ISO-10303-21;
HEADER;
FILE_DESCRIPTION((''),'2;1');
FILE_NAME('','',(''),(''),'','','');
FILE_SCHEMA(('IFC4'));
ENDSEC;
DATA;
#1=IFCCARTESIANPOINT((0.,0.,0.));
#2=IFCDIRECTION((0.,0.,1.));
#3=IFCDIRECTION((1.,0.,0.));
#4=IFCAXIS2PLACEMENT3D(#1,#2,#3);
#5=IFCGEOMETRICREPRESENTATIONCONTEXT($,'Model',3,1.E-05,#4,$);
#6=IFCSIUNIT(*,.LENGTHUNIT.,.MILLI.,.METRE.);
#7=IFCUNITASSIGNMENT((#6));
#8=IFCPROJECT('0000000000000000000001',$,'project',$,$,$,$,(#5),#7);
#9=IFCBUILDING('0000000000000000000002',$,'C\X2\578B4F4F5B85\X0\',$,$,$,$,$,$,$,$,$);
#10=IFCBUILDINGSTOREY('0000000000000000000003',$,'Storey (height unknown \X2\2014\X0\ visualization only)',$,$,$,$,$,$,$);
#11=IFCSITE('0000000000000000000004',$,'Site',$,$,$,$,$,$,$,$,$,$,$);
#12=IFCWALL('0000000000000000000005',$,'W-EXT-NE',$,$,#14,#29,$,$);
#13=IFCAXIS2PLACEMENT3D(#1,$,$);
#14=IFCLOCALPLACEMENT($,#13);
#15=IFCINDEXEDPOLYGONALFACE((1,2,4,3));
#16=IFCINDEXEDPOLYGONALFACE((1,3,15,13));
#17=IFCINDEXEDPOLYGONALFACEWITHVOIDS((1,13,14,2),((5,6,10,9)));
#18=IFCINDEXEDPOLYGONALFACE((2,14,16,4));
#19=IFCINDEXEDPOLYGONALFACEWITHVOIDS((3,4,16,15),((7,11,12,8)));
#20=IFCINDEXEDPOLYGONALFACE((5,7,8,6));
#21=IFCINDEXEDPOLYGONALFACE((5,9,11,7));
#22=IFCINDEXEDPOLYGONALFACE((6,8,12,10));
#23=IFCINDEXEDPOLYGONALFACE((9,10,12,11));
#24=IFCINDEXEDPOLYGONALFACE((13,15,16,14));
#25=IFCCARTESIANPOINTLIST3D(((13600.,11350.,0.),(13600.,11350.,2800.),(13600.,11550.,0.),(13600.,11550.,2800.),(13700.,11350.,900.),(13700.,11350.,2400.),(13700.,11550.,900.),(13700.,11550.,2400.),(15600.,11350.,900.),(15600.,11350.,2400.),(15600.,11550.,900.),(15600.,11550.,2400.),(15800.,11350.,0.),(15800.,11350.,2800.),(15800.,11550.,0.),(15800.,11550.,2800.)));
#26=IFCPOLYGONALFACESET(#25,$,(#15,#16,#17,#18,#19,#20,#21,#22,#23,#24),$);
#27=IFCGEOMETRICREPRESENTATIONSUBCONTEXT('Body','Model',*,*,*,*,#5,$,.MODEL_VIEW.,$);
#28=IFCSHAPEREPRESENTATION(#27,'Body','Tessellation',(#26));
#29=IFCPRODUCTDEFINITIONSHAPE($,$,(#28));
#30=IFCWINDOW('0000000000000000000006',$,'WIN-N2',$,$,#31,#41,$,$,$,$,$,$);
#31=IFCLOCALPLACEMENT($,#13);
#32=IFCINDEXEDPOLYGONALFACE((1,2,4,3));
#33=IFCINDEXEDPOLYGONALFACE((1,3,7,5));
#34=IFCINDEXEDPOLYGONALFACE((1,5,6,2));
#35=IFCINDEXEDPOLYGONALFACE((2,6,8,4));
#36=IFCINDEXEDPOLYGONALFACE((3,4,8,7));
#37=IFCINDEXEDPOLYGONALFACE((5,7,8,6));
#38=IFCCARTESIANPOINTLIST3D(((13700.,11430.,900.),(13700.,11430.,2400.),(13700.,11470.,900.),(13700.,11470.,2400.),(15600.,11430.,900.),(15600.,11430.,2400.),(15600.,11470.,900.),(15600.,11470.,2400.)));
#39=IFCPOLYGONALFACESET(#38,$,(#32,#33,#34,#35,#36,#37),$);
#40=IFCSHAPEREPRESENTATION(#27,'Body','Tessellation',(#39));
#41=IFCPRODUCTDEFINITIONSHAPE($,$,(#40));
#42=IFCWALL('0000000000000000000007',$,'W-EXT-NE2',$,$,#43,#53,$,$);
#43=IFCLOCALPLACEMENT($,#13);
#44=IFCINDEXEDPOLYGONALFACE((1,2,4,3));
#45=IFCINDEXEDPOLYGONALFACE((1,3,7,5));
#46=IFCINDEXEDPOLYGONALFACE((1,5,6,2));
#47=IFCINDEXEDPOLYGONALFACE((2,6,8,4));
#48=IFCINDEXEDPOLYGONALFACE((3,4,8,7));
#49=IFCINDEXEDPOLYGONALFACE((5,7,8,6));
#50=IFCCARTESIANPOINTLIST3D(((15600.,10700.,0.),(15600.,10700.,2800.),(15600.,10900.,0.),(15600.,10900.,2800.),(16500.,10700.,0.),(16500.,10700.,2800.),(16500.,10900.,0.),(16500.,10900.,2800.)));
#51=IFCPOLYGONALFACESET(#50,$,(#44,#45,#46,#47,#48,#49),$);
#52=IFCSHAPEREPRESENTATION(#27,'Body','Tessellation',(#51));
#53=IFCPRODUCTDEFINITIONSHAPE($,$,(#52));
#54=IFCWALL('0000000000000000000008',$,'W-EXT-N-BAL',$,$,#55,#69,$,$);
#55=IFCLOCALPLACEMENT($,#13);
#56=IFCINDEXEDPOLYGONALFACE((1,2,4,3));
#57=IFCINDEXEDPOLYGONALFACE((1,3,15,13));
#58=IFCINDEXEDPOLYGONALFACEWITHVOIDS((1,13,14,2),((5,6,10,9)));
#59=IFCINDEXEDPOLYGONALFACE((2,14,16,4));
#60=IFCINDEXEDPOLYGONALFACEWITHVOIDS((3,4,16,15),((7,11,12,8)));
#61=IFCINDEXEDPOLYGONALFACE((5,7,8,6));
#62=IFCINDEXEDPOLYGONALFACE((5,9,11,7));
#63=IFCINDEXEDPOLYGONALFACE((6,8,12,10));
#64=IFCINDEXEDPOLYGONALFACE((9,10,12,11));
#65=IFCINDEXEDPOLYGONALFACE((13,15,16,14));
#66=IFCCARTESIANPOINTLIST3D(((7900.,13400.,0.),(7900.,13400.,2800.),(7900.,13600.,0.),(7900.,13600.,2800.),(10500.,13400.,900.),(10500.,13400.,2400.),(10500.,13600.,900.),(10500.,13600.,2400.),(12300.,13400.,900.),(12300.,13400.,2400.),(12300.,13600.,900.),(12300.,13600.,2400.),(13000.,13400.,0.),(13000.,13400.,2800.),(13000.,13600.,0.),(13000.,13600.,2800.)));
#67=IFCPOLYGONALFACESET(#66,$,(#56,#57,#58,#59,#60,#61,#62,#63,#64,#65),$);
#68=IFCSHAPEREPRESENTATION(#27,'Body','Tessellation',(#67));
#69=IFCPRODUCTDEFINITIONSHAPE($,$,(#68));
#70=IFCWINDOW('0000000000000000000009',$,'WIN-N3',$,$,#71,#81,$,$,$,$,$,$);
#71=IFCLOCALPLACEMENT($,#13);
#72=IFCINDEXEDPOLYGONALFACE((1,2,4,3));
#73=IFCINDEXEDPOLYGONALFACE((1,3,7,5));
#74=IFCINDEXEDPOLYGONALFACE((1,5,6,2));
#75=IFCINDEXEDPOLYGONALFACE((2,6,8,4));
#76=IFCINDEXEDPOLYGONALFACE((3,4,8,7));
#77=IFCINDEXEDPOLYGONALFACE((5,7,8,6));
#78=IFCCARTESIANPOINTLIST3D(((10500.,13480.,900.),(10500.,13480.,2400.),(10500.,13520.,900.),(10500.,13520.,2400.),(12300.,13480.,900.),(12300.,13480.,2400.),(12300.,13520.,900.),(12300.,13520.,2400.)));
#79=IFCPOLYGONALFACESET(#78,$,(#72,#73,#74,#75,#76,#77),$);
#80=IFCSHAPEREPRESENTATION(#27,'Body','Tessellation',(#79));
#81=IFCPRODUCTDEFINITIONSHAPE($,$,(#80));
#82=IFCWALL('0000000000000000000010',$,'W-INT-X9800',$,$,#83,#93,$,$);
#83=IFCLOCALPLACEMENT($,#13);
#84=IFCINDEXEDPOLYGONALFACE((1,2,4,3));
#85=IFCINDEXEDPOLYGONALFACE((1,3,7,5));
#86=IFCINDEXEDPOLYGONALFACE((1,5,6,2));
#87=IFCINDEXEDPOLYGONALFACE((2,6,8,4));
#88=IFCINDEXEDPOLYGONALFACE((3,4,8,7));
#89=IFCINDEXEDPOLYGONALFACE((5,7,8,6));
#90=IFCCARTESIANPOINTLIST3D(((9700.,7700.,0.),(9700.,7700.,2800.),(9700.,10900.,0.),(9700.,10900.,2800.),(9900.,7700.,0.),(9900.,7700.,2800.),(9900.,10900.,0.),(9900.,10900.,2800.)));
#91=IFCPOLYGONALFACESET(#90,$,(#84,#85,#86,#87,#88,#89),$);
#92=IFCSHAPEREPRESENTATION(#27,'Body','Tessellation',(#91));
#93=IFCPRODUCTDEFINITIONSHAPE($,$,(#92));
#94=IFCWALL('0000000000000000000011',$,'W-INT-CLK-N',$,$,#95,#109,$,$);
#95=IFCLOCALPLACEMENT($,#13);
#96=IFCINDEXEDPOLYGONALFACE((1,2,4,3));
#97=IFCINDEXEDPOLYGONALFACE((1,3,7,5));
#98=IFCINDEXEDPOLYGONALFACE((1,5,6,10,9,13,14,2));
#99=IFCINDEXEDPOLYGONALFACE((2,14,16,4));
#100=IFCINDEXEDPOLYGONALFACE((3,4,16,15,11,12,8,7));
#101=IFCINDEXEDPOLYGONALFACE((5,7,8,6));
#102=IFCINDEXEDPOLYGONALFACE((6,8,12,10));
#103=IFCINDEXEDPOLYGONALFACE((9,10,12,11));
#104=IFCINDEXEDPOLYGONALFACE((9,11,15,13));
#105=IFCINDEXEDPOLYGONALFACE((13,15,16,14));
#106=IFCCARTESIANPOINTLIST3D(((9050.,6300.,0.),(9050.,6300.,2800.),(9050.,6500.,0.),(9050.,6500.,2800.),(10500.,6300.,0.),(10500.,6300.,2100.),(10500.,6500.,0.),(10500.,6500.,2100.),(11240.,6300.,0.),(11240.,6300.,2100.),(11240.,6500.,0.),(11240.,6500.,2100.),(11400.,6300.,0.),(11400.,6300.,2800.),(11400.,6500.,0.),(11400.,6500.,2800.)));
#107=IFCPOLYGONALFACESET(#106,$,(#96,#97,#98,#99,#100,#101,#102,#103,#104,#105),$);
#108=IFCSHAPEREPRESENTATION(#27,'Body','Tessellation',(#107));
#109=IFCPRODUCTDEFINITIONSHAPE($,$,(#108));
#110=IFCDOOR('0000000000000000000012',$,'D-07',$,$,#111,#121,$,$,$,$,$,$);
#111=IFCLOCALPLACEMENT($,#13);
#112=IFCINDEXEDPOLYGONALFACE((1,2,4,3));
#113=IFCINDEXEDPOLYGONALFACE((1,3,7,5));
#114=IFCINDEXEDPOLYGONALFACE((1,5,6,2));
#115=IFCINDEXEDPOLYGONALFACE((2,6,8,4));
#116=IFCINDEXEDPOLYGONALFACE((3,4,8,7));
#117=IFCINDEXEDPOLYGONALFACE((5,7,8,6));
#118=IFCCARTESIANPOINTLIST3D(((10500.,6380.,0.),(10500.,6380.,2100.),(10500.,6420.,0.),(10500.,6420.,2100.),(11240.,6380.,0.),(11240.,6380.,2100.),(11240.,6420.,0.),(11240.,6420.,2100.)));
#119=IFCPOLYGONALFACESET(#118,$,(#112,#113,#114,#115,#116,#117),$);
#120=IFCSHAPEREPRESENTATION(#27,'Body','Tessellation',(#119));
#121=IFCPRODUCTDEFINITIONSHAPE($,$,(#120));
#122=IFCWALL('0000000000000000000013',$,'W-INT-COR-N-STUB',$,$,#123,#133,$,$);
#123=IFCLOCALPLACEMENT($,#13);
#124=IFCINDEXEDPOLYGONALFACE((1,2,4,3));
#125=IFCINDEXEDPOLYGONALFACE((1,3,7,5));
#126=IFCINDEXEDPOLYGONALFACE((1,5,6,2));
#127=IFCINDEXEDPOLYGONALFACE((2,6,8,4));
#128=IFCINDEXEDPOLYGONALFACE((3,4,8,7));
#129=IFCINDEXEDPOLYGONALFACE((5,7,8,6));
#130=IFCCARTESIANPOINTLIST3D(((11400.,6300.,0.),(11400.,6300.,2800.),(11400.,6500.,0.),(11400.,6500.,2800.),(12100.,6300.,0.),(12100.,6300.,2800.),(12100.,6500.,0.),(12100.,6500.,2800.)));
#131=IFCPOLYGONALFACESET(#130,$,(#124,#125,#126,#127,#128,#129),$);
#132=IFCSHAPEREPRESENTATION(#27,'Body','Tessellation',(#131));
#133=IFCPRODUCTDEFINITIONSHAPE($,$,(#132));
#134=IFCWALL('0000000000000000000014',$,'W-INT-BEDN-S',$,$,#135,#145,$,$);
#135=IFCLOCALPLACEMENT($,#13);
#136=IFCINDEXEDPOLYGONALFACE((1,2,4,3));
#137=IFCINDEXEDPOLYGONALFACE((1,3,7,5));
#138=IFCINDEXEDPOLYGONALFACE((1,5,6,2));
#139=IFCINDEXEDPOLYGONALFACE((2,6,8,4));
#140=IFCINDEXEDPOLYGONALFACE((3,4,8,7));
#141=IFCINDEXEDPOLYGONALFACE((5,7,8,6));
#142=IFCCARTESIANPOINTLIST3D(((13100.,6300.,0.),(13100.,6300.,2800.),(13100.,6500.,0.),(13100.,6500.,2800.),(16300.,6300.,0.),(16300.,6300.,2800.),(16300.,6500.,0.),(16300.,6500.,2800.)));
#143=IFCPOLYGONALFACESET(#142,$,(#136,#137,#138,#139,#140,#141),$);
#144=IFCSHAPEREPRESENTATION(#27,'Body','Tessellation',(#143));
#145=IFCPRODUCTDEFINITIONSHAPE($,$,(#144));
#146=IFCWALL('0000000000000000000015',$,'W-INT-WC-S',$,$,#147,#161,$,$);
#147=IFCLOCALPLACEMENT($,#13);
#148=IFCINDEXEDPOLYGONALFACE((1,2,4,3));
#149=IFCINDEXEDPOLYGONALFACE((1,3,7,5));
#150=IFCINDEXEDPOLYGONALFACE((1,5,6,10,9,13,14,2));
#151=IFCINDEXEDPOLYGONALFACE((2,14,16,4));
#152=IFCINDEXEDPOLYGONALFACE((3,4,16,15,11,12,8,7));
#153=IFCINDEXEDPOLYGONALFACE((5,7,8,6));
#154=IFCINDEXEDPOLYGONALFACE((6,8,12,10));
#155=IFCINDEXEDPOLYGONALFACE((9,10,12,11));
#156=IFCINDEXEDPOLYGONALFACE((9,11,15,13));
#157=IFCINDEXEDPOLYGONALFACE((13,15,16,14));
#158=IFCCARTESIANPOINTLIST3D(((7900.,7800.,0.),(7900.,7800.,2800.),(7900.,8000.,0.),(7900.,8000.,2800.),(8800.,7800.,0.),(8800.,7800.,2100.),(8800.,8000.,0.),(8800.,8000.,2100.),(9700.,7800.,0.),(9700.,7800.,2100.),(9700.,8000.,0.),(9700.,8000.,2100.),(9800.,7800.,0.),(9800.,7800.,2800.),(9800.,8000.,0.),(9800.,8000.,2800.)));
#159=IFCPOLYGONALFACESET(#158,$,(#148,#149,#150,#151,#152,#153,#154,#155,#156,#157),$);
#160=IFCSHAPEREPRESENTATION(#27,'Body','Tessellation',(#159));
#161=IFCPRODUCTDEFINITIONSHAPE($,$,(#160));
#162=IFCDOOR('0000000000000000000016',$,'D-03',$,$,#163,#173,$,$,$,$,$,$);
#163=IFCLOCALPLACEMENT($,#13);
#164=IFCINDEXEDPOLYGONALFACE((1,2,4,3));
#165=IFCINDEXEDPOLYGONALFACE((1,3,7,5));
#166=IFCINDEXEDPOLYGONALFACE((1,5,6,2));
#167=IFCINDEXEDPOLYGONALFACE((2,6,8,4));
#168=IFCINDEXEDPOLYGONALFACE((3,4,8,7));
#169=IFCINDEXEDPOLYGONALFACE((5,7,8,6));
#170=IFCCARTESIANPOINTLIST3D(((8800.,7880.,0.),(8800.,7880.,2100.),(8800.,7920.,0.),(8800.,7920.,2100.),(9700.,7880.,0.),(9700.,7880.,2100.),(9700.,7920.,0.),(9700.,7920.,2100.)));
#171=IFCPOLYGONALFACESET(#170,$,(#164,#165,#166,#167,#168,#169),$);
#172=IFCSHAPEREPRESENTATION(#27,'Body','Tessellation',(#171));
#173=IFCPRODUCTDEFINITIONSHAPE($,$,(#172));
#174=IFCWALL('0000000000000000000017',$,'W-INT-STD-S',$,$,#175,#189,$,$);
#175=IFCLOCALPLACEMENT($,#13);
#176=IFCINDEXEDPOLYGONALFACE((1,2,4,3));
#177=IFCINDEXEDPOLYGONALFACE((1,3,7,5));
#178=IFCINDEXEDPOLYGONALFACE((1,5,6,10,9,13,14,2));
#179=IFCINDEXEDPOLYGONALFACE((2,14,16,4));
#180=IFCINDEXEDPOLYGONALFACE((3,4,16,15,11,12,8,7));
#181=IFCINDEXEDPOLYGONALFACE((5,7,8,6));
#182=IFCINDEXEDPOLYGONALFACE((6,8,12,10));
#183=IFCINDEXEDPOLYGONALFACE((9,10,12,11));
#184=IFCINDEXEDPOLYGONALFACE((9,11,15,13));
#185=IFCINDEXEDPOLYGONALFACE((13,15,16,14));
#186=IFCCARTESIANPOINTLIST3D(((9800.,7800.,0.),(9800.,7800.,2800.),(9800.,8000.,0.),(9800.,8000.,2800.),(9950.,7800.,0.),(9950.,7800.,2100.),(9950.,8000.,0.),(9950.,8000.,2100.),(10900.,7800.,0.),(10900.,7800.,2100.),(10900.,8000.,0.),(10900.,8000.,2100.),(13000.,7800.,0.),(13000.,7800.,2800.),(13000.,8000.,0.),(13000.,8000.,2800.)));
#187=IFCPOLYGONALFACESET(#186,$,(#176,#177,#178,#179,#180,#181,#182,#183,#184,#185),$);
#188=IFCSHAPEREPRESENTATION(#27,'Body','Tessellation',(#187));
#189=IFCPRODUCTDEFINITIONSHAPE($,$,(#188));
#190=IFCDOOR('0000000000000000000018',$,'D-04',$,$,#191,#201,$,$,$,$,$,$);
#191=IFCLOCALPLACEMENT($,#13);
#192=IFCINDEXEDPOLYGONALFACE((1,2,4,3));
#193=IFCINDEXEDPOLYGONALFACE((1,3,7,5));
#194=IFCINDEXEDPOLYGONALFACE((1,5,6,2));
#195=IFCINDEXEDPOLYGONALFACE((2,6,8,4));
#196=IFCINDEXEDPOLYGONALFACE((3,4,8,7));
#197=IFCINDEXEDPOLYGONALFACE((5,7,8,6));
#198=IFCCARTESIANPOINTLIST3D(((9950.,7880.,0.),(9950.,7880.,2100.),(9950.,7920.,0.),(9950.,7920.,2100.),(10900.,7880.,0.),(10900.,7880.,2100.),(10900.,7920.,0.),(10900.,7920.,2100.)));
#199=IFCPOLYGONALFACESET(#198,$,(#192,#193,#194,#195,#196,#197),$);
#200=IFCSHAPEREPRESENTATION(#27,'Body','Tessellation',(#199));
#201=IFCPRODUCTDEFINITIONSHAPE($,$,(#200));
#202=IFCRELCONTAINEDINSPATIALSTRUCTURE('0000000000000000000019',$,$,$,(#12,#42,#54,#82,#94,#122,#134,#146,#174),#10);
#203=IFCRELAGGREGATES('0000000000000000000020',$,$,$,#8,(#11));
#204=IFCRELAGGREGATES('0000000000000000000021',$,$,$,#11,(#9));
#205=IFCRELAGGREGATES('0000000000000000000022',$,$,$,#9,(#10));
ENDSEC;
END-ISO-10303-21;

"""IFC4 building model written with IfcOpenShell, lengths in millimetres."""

from ifc_helpers import new_model, si_unit, frame, frame_2d, origin_with_axes, place, context, subcontext, project, spatial, rectangle, extrude, element, fill, save


model = new_model("IFC4")

# Units and contexts
model_context = context("Model", 3, precision=1e-05, world=origin_with_axes())
body_context = subcontext(model_context, "Body", "Model", "MODEL_VIEW")
ifc_project = project(units=[si_unit("LENGTHUNIT", "METRE", prefix="MILLI")], contexts=[model_context])

# Site, building, storey
site = spatial("IfcSite", under=ifc_project, Name="Site")
building = spatial("IfcBuilding", under=site, Name="C型住宅")
storey = spatial("IfcBuildingStorey", under=building, Name="Storey (height unknown — visualization only)")

# Wall, opening, window
wall_1_placement = place(None, frame((13600.0, 11350.0, 0.0), z_axis=(0.0, 0.0, 1.0), x_axis=(1.0, 0.0, 0.0)))
wall_1 = element("IfcWall", 1, at=wall_1_placement, inside=storey, Name="W-EXT-NE", context=body_context, shape_type="SweptSolid", body=[
    extrude(rectangle(XDim=2200.0, YDim=200.0, at=frame_2d((1100.0, 100.0))), origin_with_axes(), (0.0, 0.0, 1.0), 2800.0),
])
opening_1_placement = place(wall_1_placement, frame((100.0, 0.0, 900.0)))
opening_1 = element("IfcOpeningElement", 2, at=opening_1_placement, cuts=wall_1, context=body_context, shape_type="SweptSolid", body=[
    extrude(rectangle(XDim=1900.0, YDim=200.0, at=frame_2d((950.0, 100.0))), origin_with_axes(), (0.0, 0.0, 1.0), 1500.0),
])
window_1_placement = place(wall_1_placement, frame((100.0, 80.0, 900.0)))
window_1 = element("IfcWindow", 3, at=window_1_placement, Name="WIN-N2", context=body_context, shape_type="SweptSolid", body=[
    extrude(rectangle(XDim=1900.0, YDim=40.0, at=frame_2d((950.0, 20.0))), origin_with_axes(), (0.0, 0.0, 1.0), 1500.0),
])
fill(opening_1, window_1)

# Wall
wall_2_placement = place(None, frame((15600.0, 10700.0, 0.0), z_axis=(0.0, 0.0, 1.0), x_axis=(1.0, 0.0, 0.0)))
element("IfcWall", 4, at=wall_2_placement, inside=storey, Name="W-EXT-NE2", context=body_context, shape_type="SweptSolid", body=[
    extrude(rectangle(XDim=900.0, YDim=200.0, at=frame_2d((450.0, 100.0))), origin_with_axes(), (0.0, 0.0, 1.0), 2800.0),
])

# Wall, opening, window
wall_3_placement = place(None, frame((7900.0, 13400.0, 0.0), z_axis=(0.0, 0.0, 1.0), x_axis=(1.0, 0.0, 0.0)))
wall_3 = element("IfcWall", 5, at=wall_3_placement, inside=storey, Name="W-EXT-N-BAL", context=body_context, shape_type="SweptSolid", body=[
    extrude(rectangle(XDim=5100.0, YDim=200.0, at=frame_2d((2550.0, 100.0))), origin_with_axes(), (0.0, 0.0, 1.0), 2800.0),
])
opening_2_placement = place(wall_3_placement, frame((2600.0, 0.0, 900.0)))
opening_2 = element("IfcOpeningElement", 6, at=opening_2_placement, cuts=wall_3, context=body_context, shape_type="SweptSolid", body=[
    extrude(rectangle(XDim=1800.0, YDim=200.0, at=frame_2d((900.0, 100.0))), origin_with_axes(), (0.0, 0.0, 1.0), 1500.0),
])
window_2_placement = place(wall_3_placement, frame((2600.0, 80.0, 900.0)))
window_2 = element("IfcWindow", 7, at=window_2_placement, Name="WIN-N3", context=body_context, shape_type="SweptSolid", body=[
    extrude(rectangle(XDim=1800.0, YDim=40.0, at=frame_2d((900.0, 20.0))), origin_with_axes(), (0.0, 0.0, 1.0), 1500.0),
])
fill(opening_2, window_2)

# Wall
wall_4_placement = place(None, frame((9700.0, 7700.0, 0.0), z_axis=(0.0, 0.0, 1.0), x_axis=(1.0, 0.0, 0.0)))
element("IfcWall", 8, at=wall_4_placement, inside=storey, Name="W-INT-X9800", context=body_context, shape_type="SweptSolid", body=[
    extrude(rectangle(XDim=200.0, YDim=3200.0, at=frame_2d((100.0, 1600.0))), origin_with_axes(), (0.0, 0.0, 1.0), 2800.0),
])

# Wall, opening, door
wall_5_placement = place(None, frame((9050.0, 6300.0, 0.0), z_axis=(0.0, 0.0, 1.0), x_axis=(1.0, 0.0, 0.0)))
wall_5 = element("IfcWall", 9, at=wall_5_placement, inside=storey, Name="W-INT-CLK-N", context=body_context, shape_type="SweptSolid", body=[
    extrude(rectangle(XDim=2350.0, YDim=200.0, at=frame_2d((1175.0, 100.0))), origin_with_axes(), (0.0, 0.0, 1.0), 2800.0),
])
opening_3_placement = place(wall_5_placement, frame((1450.0, 0.0, 0.0)))
opening_3 = element("IfcOpeningElement", 10, at=opening_3_placement, cuts=wall_5, context=body_context, shape_type="SweptSolid", body=[
    extrude(rectangle(XDim=740.0, YDim=200.0, at=frame_2d((370.0, 100.0))), origin_with_axes(), (0.0, 0.0, 1.0), 2100.0),
])
door_1_placement = place(wall_5_placement, frame((1450.0, 80.0, 0.0)))
door_1 = element("IfcDoor", 11, at=door_1_placement, Name="D-07", context=body_context, shape_type="SweptSolid", body=[
    extrude(rectangle(XDim=740.0, YDim=40.0, at=frame_2d((370.0, 20.0))), origin_with_axes(), (0.0, 0.0, 1.0), 2100.0),
])
fill(opening_3, door_1)

# Walls
wall_6_placement = place(None, frame((11400.0, 6300.0, 0.0), z_axis=(0.0, 0.0, 1.0), x_axis=(1.0, 0.0, 0.0)))
element("IfcWall", 12, at=wall_6_placement, inside=storey, Name="W-INT-COR-N-STUB", context=body_context, shape_type="SweptSolid", body=[
    extrude(rectangle(XDim=700.0, YDim=200.0, at=frame_2d((350.0, 100.0))), origin_with_axes(), (0.0, 0.0, 1.0), 2800.0),
])
wall_7_placement = place(None, frame((13100.0, 6300.0, 0.0), z_axis=(0.0, 0.0, 1.0), x_axis=(1.0, 0.0, 0.0)))
element("IfcWall", 13, at=wall_7_placement, inside=storey, Name="W-INT-BEDN-S", context=body_context, shape_type="SweptSolid", body=[
    extrude(rectangle(XDim=3200.0, YDim=200.0, at=frame_2d((1600.0, 100.0))), origin_with_axes(), (0.0, 0.0, 1.0), 2800.0),
])

# Walls, openings, doors
wall_8_placement = place(None, frame((7900.0, 7800.0, 0.0), z_axis=(0.0, 0.0, 1.0), x_axis=(1.0, 0.0, 0.0)))
wall_8 = element("IfcWall", 14, at=wall_8_placement, inside=storey, Name="W-INT-WC-S", context=body_context, shape_type="SweptSolid", body=[
    extrude(rectangle(XDim=1900.0, YDim=200.0, at=frame_2d((950.0, 100.0))), origin_with_axes(), (0.0, 0.0, 1.0), 2800.0),
])
opening_4_placement = place(wall_8_placement, frame((900.0, 0.0, 0.0)))
opening_4 = element("IfcOpeningElement", 15, at=opening_4_placement, cuts=wall_8, context=body_context, shape_type="SweptSolid", body=[
    extrude(rectangle(XDim=900.0, YDim=200.0, at=frame_2d((450.0, 100.0))), origin_with_axes(), (0.0, 0.0, 1.0), 2100.0),
])
door_2_placement = place(wall_8_placement, frame((900.0, 80.0, 0.0)))
door_2 = element("IfcDoor", 16, at=door_2_placement, Name="D-03", context=body_context, shape_type="SweptSolid", body=[
    extrude(rectangle(XDim=900.0, YDim=40.0, at=frame_2d((450.0, 20.0))), origin_with_axes(), (0.0, 0.0, 1.0), 2100.0),
])
fill(opening_4, door_2)
wall_9_placement = place(None, frame((9800.0, 7800.0, 0.0), z_axis=(0.0, 0.0, 1.0), x_axis=(1.0, 0.0, 0.0)))
wall_9 = element("IfcWall", 17, at=wall_9_placement, inside=storey, Name="W-INT-STD-S", context=body_context, shape_type="SweptSolid", body=[
    extrude(rectangle(XDim=3200.0, YDim=200.0, at=frame_2d((1600.0, 100.0))), origin_with_axes(), (0.0, 0.0, 1.0), 2800.0),
])
opening_5_placement = place(wall_9_placement, frame((150.0, 0.0, 0.0)))
opening_5 = element("IfcOpeningElement", 18, at=opening_5_placement, cuts=wall_9, context=body_context, shape_type="SweptSolid", body=[
    extrude(rectangle(XDim=950.0, YDim=200.0, at=frame_2d((475.0, 100.0))), origin_with_axes(), (0.0, 0.0, 1.0), 2100.0),
])
door_3_placement = place(wall_9_placement, frame((150.0, 80.0, 0.0)))
door_3 = element("IfcDoor", 19, at=door_3_placement, Name="D-04", context=body_context, shape_type="SweptSolid", body=[
    extrude(rectangle(XDim=950.0, YDim=40.0, at=frame_2d((475.0, 20.0))), origin_with_axes(), (0.0, 0.0, 1.0), 2100.0),
])
fill(opening_5, door_3)

save(model, "model.ifc")
